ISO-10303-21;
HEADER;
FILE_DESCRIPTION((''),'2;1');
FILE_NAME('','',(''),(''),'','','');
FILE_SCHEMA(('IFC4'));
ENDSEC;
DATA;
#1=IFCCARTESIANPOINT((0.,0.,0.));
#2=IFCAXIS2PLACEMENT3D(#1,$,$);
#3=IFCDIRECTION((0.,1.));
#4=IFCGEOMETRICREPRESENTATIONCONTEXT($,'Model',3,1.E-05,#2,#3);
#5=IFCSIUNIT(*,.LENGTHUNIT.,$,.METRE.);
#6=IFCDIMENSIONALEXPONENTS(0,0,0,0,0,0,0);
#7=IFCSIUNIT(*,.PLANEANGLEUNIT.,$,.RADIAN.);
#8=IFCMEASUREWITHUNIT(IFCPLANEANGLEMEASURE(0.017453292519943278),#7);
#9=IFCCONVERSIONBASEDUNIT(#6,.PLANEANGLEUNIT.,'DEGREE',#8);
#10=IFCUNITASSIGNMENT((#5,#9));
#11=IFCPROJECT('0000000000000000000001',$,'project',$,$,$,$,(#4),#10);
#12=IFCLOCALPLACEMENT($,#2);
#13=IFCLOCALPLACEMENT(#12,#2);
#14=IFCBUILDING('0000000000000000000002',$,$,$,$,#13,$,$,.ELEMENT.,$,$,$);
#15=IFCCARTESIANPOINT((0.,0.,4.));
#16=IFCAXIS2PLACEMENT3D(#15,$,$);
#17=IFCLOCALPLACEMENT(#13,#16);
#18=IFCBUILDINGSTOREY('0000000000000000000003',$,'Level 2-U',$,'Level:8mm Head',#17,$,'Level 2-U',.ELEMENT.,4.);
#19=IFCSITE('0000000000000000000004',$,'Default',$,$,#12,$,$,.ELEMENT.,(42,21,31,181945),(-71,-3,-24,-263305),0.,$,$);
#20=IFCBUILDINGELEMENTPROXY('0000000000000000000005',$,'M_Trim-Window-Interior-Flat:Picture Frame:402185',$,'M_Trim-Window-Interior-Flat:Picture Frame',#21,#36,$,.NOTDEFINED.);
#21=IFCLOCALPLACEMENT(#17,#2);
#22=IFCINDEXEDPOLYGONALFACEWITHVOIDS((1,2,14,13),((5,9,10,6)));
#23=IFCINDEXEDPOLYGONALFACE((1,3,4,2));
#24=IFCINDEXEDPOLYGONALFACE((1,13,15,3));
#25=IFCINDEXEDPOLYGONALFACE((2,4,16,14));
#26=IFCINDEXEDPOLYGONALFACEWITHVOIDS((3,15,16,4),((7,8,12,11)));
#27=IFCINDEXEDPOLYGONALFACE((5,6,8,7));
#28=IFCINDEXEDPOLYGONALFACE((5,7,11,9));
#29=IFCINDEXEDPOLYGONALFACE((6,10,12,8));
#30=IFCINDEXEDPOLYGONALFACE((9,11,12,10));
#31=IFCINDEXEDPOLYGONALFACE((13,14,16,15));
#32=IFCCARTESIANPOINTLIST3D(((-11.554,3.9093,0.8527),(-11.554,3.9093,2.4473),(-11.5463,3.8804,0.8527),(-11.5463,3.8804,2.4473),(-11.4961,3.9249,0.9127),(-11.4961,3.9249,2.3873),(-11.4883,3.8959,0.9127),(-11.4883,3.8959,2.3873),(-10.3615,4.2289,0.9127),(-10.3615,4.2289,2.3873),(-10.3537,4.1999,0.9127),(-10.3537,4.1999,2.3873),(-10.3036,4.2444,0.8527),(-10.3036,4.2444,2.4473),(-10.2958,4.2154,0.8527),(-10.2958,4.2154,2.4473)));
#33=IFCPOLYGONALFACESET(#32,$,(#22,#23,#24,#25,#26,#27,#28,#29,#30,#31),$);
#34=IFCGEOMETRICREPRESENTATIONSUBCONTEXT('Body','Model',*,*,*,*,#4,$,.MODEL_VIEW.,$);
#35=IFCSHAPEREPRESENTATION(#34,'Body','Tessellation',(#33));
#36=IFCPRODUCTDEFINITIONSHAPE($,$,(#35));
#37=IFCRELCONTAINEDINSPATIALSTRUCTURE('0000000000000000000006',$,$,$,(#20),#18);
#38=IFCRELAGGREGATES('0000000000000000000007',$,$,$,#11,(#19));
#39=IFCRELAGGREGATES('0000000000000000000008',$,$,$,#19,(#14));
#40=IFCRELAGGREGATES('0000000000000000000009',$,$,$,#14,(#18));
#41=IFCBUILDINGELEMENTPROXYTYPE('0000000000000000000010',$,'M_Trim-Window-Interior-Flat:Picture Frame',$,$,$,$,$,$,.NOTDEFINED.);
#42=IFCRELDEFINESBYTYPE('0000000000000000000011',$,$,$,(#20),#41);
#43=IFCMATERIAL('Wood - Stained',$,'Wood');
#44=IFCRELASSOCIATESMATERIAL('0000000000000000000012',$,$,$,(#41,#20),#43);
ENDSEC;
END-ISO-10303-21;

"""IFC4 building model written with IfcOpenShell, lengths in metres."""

from ifc_helpers import new_model, entity, si_unit, converted_unit, direction, frame, origin, place, context, subcontext, project, spatial, polyline, outline, extrude, source, transform, mapped, material, type_object, type_shapes, element, save


model = new_model("IFC4")

# Units and contexts
model_context = context("Model", 3, precision=1e-05, world=origin(), true_north=direction((0.0, 1.0)))
body_context = subcontext(model_context, "Body", "Model", "MODEL_VIEW")
ifc_project = project(units=[si_unit("LENGTHUNIT", "METRE"), converted_unit("PLANEANGLEUNIT", "DEGREE", entity("IfcPlaneAngleMeasure", 0.017453292519943278), si_unit("PLANEANGLEUNIT", "RADIAN"), dimensions=[0, 0, 0, 0, 0, 0, 0])], contexts=[model_context])

# Site, building, storey
site_placement = place(None, origin())
site = spatial("IfcSite", under=ifc_project, at=site_placement, Name="Default", CompositionType="ELEMENT", RefLatitude=(42, 21, 31, 181945), RefLongitude=(-71, -3, -24, -263305), RefElevation=0.0)
building_placement = place(site_placement, origin())
building = spatial("IfcBuilding", under=site, at=building_placement, CompositionType="ELEMENT")
storey_placement = place(building_placement, frame((0.0, 0.0, 4.0)))
storey = spatial("IfcBuildingStorey", under=building, at=storey_placement, Name="Level 2-U", ObjectType="Level:8mm Head", LongName="Level 2-U", CompositionType="ELEMENT", Elevation=4.0)

# Building element proxy
ifc_material_1 = material(Name="Wood - Stained", Category="Wood")
building_element_proxy_type_1 = type_object("IfcBuildingElementProxyType", Name="M_Trim-Window-Interior-Flat:Picture Frame", PredefinedType="NOTDEFINED", material=ifc_material_1)
shared_shape_1 = source(origin(), body_context, "Body", "SweptSolid", [
    extrude(outline(polyline([(-0.6473, -0.7973), (0.6473, -0.7973), (0.6473, 0.7973), (-0.6473, 0.7973), (-0.6473, -0.7973)]), holes=[polyline([(-0.5873, -0.7373), (-0.5873, 0.7373), (0.5873, 0.7373), (0.5873, -0.7373), (-0.5873, -0.7373)])]), frame((0.0, -0.75, 0.0), z_axis=(0.0, 0.0, 1.0), x_axis=(-1.0, 0.0, 0.0)), (0.0, 0.0, 1.0), 0.03),
])
type_shapes(building_element_proxy_type_1, [shared_shape_1])
for number, where, z_axis, x_axis, name in (
    (1, (-10.921, 4.0479, 2.4), (-0.258819, 0.965926, 0.0), (-0.965926, -0.258819, 0.0), "M_Trim-Window-Interior-Flat:Picture Frame:402185"),
):
    element("IfcBuildingElementProxy", number, at=place(storey_placement, frame(where, z_axis=z_axis, x_axis=x_axis)), inside=storey, type_object=building_element_proxy_type_1, material=ifc_material_1, Name=name, ObjectType="M_Trim-Window-Interior-Flat:Picture Frame", PredefinedType="NOTDEFINED", context=body_context, shape_type="MappedRepresentation", body=[
        mapped(shared_shape_1, transform((0.0, 0.0, 0.0), scale=1.0)),
    ])

save(model, "model.ifc")
